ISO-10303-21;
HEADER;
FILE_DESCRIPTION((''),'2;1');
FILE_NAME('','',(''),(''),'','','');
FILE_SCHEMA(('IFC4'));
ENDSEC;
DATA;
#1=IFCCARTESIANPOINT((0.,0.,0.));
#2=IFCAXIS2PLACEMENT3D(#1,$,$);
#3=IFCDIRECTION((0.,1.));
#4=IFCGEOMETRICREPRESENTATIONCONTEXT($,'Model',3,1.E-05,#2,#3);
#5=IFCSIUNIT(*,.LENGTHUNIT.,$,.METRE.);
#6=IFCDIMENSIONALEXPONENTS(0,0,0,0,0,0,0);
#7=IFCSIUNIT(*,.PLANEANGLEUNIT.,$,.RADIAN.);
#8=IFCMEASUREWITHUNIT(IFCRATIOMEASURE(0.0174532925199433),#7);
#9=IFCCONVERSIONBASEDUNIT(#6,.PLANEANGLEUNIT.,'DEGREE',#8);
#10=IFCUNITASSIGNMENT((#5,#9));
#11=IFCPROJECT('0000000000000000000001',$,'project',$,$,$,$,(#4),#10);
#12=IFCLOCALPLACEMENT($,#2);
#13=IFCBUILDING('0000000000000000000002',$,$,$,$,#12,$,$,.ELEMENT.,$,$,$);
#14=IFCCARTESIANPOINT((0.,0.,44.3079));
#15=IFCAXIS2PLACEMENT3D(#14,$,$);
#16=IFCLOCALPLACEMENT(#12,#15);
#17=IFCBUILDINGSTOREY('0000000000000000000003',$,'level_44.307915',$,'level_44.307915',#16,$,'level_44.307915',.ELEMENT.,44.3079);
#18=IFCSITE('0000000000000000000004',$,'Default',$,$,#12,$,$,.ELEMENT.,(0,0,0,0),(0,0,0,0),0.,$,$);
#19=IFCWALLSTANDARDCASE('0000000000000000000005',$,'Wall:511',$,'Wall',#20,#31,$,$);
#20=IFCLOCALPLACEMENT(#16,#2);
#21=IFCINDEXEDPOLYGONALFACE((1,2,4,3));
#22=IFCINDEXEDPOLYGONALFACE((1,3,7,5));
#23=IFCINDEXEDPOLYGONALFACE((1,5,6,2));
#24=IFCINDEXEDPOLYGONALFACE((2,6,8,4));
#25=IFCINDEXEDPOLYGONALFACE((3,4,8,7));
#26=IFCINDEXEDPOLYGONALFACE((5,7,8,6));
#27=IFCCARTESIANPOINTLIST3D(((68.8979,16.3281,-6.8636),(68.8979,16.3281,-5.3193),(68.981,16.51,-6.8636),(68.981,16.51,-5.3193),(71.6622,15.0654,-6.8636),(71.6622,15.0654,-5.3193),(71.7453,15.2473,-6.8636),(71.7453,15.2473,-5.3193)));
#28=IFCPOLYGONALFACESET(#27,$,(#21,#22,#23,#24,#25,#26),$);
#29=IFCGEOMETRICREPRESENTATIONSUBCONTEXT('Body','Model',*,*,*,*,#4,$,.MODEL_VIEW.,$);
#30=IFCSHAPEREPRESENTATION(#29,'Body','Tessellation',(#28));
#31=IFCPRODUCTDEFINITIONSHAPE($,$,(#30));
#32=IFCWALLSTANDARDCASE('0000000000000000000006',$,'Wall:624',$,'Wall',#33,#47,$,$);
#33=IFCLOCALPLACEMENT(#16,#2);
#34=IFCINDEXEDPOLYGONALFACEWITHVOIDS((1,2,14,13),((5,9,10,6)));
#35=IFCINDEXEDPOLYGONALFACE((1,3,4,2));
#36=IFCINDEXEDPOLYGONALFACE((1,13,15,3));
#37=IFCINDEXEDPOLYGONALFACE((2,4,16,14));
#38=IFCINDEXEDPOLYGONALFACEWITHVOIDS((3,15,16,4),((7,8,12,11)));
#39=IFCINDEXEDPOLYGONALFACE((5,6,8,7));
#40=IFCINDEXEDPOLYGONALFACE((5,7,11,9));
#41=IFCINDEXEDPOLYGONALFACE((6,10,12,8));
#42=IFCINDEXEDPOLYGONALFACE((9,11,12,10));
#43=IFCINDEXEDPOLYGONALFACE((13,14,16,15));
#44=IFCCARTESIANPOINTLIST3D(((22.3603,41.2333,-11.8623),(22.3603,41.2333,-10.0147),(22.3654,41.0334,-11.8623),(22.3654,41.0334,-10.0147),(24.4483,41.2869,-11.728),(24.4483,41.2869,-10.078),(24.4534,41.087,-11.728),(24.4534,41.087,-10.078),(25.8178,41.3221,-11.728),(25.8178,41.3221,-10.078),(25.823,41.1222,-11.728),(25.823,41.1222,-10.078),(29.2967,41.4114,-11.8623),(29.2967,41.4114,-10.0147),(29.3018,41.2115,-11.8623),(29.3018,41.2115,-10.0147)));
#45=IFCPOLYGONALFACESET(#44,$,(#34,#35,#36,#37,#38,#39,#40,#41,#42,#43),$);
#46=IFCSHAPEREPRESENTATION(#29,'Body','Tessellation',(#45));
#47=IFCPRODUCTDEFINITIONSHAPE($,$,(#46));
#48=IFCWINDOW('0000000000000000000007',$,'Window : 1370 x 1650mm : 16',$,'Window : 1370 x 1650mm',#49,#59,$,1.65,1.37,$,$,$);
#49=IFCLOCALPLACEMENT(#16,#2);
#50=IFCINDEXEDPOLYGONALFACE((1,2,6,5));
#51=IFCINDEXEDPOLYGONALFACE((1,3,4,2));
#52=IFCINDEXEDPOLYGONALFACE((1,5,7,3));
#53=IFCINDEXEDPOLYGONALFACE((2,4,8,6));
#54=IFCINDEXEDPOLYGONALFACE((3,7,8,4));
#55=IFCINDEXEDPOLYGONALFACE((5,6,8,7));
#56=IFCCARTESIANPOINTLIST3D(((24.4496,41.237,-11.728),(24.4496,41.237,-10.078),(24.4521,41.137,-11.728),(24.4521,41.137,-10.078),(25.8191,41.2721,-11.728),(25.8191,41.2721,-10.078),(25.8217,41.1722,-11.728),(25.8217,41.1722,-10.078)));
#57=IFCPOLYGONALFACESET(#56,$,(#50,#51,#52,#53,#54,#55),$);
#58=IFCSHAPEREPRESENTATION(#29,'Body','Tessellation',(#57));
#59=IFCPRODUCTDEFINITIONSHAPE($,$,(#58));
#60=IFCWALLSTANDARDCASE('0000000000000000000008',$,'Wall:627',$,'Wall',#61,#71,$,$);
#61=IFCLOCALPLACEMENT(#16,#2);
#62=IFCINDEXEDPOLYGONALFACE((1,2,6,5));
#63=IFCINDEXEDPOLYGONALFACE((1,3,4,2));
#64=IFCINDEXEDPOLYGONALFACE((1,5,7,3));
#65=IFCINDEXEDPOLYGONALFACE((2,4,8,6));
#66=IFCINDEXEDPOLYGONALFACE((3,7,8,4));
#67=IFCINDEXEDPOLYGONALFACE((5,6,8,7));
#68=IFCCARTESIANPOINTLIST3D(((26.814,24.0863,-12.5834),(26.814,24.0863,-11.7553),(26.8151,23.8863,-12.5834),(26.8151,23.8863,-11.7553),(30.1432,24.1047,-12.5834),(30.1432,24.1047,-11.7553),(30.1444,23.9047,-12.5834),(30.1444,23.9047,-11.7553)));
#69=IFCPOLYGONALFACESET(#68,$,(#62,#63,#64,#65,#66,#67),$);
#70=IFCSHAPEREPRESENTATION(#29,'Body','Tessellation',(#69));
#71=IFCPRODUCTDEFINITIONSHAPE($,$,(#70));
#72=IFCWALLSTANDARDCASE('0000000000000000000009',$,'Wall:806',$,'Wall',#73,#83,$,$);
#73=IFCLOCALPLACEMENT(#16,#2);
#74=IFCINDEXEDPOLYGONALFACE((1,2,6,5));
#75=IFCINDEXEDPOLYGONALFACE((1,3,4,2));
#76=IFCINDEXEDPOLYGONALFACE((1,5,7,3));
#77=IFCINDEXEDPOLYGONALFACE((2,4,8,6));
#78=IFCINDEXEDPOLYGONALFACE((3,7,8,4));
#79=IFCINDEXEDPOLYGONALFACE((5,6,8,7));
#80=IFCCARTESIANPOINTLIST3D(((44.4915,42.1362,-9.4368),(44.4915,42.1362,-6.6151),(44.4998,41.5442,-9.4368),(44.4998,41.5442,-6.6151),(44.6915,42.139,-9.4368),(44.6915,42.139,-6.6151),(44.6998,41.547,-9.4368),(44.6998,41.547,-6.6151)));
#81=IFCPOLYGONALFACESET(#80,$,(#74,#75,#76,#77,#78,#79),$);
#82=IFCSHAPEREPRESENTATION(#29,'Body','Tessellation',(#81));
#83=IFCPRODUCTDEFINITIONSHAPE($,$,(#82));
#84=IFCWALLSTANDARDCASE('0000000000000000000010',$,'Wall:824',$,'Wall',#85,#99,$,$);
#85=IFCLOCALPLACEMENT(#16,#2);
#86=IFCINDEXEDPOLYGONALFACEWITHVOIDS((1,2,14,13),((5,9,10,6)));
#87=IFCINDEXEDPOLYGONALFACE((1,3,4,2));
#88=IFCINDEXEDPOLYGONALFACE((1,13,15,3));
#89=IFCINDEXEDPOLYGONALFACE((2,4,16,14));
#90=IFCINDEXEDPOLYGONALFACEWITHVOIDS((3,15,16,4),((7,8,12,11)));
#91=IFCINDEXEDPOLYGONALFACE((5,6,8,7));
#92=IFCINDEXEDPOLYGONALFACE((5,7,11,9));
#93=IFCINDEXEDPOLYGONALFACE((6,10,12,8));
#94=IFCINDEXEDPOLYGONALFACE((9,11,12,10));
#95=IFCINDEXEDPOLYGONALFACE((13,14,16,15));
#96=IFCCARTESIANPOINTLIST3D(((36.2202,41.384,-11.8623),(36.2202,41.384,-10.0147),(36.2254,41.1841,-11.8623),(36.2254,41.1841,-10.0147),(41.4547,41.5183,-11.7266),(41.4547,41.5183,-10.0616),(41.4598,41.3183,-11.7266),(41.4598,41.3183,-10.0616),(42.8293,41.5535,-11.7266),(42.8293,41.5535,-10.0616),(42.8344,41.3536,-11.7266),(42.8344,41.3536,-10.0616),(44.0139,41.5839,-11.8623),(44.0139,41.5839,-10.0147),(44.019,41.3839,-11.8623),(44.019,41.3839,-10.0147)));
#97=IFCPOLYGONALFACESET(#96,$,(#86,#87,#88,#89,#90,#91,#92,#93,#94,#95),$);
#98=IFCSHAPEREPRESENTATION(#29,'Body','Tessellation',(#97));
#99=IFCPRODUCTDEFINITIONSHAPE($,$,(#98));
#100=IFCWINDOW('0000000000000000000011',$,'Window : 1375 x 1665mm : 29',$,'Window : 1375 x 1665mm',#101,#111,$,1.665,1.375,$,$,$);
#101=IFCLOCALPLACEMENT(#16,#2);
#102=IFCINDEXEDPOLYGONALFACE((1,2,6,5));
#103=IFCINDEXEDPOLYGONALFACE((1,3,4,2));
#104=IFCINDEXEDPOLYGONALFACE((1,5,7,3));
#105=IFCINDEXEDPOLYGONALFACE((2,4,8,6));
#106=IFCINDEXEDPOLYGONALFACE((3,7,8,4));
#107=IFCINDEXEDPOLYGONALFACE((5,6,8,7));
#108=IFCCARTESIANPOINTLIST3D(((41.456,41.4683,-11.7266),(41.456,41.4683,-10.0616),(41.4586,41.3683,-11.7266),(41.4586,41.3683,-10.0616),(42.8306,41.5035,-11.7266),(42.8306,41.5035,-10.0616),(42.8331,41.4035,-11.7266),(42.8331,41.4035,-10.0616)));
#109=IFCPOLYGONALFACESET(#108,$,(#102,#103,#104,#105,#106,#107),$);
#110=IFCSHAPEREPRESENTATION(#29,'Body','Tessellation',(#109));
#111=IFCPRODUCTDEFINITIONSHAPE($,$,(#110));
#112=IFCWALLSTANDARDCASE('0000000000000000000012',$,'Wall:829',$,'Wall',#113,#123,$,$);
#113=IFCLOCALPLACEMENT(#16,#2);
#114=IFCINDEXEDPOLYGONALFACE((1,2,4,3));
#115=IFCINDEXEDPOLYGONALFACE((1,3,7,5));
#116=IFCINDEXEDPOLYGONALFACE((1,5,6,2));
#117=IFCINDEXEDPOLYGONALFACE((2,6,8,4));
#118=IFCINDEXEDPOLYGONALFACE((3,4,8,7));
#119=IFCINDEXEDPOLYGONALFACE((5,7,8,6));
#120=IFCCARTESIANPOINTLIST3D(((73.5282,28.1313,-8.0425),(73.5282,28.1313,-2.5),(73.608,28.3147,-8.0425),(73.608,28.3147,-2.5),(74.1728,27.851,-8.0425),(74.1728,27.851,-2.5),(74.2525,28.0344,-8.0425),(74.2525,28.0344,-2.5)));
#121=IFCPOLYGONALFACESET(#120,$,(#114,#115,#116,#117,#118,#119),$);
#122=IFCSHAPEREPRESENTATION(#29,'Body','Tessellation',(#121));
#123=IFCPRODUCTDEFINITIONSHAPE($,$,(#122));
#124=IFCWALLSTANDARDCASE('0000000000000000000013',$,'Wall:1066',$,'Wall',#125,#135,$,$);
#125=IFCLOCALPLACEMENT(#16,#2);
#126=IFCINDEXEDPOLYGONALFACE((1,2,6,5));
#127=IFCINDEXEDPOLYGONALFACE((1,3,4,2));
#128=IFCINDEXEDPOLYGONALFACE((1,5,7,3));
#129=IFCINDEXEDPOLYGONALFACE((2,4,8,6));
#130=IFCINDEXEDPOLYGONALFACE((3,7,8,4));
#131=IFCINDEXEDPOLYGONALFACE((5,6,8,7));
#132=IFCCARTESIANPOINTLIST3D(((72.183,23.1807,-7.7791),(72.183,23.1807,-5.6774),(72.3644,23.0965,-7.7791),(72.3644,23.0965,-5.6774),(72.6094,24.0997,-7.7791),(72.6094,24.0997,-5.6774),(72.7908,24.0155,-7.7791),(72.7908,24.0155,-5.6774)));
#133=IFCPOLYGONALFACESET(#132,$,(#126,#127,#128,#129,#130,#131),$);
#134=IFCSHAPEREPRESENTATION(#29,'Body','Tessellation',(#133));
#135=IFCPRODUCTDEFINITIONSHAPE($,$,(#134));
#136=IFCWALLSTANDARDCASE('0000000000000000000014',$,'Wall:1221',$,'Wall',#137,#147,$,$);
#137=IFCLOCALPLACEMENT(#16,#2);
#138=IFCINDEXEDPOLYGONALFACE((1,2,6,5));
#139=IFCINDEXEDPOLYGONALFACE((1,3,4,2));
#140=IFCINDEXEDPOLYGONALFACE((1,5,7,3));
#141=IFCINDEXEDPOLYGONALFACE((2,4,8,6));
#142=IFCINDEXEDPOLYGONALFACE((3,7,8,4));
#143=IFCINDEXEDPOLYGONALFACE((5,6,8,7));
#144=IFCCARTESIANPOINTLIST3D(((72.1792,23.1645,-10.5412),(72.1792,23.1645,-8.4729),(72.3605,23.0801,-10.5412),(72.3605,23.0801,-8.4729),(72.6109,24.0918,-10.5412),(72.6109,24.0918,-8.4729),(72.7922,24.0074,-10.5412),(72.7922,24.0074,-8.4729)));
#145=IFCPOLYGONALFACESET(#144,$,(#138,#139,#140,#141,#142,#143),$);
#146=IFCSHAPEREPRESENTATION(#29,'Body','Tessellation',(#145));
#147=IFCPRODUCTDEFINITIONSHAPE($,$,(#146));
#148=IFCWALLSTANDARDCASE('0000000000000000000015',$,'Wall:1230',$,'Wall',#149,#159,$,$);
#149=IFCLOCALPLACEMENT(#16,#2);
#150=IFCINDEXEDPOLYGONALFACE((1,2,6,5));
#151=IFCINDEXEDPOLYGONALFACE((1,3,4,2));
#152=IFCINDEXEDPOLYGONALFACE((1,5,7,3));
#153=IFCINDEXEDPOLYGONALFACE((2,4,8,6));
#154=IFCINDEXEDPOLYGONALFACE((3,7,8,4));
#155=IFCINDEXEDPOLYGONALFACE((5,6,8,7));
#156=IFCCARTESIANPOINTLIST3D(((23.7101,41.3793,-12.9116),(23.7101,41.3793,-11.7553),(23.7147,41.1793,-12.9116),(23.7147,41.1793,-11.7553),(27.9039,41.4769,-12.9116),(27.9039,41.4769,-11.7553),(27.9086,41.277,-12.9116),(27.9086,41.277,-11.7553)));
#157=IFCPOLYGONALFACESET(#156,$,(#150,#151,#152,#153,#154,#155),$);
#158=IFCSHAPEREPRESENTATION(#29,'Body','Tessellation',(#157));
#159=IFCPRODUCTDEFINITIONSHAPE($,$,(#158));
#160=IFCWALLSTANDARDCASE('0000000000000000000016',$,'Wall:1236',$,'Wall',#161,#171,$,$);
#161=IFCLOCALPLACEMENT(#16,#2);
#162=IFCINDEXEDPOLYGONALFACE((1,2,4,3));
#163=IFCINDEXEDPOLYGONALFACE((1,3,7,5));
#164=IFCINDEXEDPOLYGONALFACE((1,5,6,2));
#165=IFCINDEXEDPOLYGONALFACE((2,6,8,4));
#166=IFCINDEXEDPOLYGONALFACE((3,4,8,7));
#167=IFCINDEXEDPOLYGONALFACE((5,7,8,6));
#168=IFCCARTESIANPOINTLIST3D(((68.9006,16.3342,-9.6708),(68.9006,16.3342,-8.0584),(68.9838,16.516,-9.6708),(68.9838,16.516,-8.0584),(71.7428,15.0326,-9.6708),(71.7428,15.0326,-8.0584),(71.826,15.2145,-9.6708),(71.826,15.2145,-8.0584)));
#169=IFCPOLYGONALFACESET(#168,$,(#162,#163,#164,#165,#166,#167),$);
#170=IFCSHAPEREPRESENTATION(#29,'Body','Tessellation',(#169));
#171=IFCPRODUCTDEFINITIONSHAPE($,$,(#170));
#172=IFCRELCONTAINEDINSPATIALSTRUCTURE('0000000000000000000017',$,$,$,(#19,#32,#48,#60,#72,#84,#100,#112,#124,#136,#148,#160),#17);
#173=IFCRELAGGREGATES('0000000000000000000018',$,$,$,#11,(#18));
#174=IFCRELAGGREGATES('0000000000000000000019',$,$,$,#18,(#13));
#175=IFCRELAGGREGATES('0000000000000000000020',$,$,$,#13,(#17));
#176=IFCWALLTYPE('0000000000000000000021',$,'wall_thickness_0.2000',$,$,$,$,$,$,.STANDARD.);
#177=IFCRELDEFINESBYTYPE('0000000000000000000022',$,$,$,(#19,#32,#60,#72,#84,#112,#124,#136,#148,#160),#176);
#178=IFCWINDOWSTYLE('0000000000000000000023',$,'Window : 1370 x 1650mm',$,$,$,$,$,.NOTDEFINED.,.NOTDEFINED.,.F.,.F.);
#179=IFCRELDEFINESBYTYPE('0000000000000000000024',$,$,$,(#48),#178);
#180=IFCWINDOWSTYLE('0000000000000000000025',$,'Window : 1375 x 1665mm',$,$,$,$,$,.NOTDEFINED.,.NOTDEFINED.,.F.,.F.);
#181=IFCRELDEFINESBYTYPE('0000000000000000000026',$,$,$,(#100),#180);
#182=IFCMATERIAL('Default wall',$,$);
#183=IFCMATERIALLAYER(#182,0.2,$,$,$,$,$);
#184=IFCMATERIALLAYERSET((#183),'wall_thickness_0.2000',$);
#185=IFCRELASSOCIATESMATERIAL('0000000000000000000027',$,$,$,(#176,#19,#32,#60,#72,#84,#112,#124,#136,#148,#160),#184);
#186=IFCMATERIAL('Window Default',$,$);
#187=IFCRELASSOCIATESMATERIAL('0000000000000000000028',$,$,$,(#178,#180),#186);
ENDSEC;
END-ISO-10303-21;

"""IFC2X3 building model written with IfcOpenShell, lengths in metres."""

from ifc_helpers import new_model, entity, si_unit, converted_unit, direction, frame, frame_2d, origin, origin_2d_with_axis, place, context, subcontext, project, spatial, polyline, rectangle, outline, extrude, source, transform, mapped, material, layer, layer_set, layer_usage, type_object, type_shapes, element, fill, save


model = new_model("IFC2X3")

# Units and contexts
model_context = context("Model", 3, precision=1e-05, world=origin(), true_north=direction((0.0, 1.0)))
body_context = subcontext(model_context, "Body", "Model", "MODEL_VIEW")
ifc_project = project(units=[si_unit("LENGTHUNIT", "METRE"), converted_unit("PLANEANGLEUNIT", "DEGREE", entity("IfcRatioMeasure", 0.0174532925199433), si_unit("PLANEANGLEUNIT", "RADIAN"), dimensions=[0, 0, 0, 0, 0, 0, 0])], contexts=[model_context])

# Site, building, storey
placement_1 = place(None, origin())
site = spatial("IfcSite", under=ifc_project, at=placement_1, Name="Default", CompositionType="ELEMENT", RefLatitude=(0, 0, 0, 0), RefLongitude=(0, 0, 0, 0), RefElevation=0.0)
building = spatial("IfcBuilding", under=site, at=placement_1, CompositionType="ELEMENT")
storey_placement = place(placement_1, frame((0.0, 0.0, 44.3079)))
storey = spatial("IfcBuildingStorey", under=building, at=storey_placement, Name="level_44.307915", ObjectType="level_44.307915", LongName="level_44.307915", CompositionType="ELEMENT", Elevation=44.3079)

# Shared definitions
ifc_material_1 = material(Name="Default wall")
ifc_layer = layer(ifc_material_1, 0.2)
ifc_layer_set = layer_set([ifc_layer], Name="wall_thickness_0.2000")
ifc_layer_usage = layer_usage(ifc_layer_set, "AXIS2", "POSITIVE", -0.1)
wall_type = type_object("IfcWallType", Name="wall_thickness_0.2000", PredefinedType="STANDARD", material=ifc_layer_set)

# Shared definitions
ifc_material_2 = material(Name="Window Default")

# Wall
placement_2 = place(placement_1, frame((0.0, 0.0, 37.4443)))
wall_1_placement = place(placement_2, frame((68.9394, 16.4191, 0.0), z_axis=(0.0, 0.0, 1.0), x_axis=(0.909599, -0.415487, 0.0)))
element("IfcWallStandardCase", 1, at=wall_1_placement, inside=storey, type_object=wall_type, material=ifc_layer_usage, Name="Wall:511", ObjectType="Wall", context=body_context, shape_type="SweptSolid", body=[
    extrude(outline(polyline([(3.039, -0.1), (3.039, 0.1), (0.0, 0.1), (0.0, -0.1), (3.039, -0.1)])), origin(), (0.0, 0.0, 1.0), 1.5443),
])

# Wall, opening, window
placement_3 = place(placement_1, frame((0.0, 0.0, 32.4456)))
wall_2_placement = place(placement_3, frame((22.3628, 41.1334, 0.0), z_axis=(0.0, 0.0, 1.0), x_axis=(0.999671, 0.025669, 0.0)))
wall_2 = element("IfcWallStandardCase", 2, at=wall_2_placement, inside=storey, type_object=wall_type, material=ifc_layer_usage, Name="Wall:624", ObjectType="Wall", context=body_context, shape_type="SweptSolid", body=[
    extrude(outline(polyline([(6.9387, -0.1), (6.9387, 0.1), (0.0, 0.1), (0.0, -0.1), (6.9387, -0.1)])), origin(), (0.0, 0.0, 1.0), 1.8476),
])
opening_1_placement = place(wall_2_placement, frame((2.0887, -0.1, 0.1344)))
opening_1 = element("IfcOpeningElement", 3, at=opening_1_placement, cuts=wall_2, ObjectType="Opening", context=body_context, shape_type="SweptSolid", body=[
    extrude(rectangle(XDim=1.37, YDim=1.65, at=frame_2d((0.825, 0.685), x_axis=(0.0, 1.0))), frame((0.0, 0.0, 0.0), z_axis=(0.0, 1.0, 0.0), x_axis=(0.0, 0.0, 1.0)), (0.0, 0.0, 1.0), 0.2),
])
window_style_1 = type_object("IfcWindowStyle", Name="Window : 1370 x 1650mm", ConstructionType="NOTDEFINED", OperationType="NOTDEFINED", ParameterTakesPrecedence=False, Sizeable=False, material=ifc_material_2)
shared_shape_1 = source(origin(), body_context, "Body", "SweptSolid", [
    extrude(rectangle(XDim=0.1, YDim=1.37, at=origin_2d_with_axis()), frame((0.685, 0.1, 0.0), z_axis=(0.0, 0.0, 1.0), x_axis=(0.0, 1.0, 0.0)), (0.0, 0.0, 1.0), 1.65),
])
type_shapes(window_style_1, [shared_shape_1])
window_1_placement = place(opening_1_placement, origin())
window_1 = element("IfcWindow", 4, at=window_1_placement, inside=storey, type_object=window_style_1, Name="Window : 1370 x 1650mm : 16", ObjectType="Window : 1370 x 1650mm", OverallHeight=1.65, OverallWidth=1.37, context=body_context, shape_type="MappedRepresentation", body=[
    mapped(shared_shape_1, transform((0.0, 0.0, 0.0), scale=1.0)),
])
fill(opening_1, window_1)

# Walls
placement_4 = place(placement_1, frame((0.0, 0.0, 31.7245)))
wall_3_placement = place(placement_4, frame((26.8146, 23.9863, 0.0), z_axis=(0.0, 0.0, 1.0), x_axis=(0.999985, 0.005525, 0.0)))
element("IfcWallStandardCase", 5, at=wall_3_placement, inside=storey, type_object=wall_type, material=ifc_layer_usage, Name="Wall:627", ObjectType="Wall", context=body_context, shape_type="SweptSolid", body=[
    extrude(outline(polyline([(3.3293, -0.1), (3.3293, 0.1), (0.0, 0.1), (0.0, -0.1), (3.3293, -0.1)])), origin(), (0.0, 0.0, 1.0), 0.8281),
])
placement_5 = place(placement_1, frame((0.0, 0.0, 34.8711)))
wall_4_placement = place(placement_5, frame((44.5998, 41.5456, 0.0), z_axis=(0.0, 0.0, 1.0), x_axis=(-0.014001, 0.999902, 0.0)))
element("IfcWallStandardCase", 6, at=wall_4_placement, inside=storey, type_object=wall_type, material=ifc_layer_usage, Name="Wall:806", ObjectType="Wall", context=body_context, shape_type="SweptSolid", body=[
    extrude(outline(polyline([(0.5921, -0.1), (0.5921, 0.1), (0.0, 0.1), (0.0, -0.1), (0.5921, -0.1)])), origin(), (0.0, 0.0, 1.0), 2.8217),
])

# Wall, opening, window
placement_6 = place(placement_1, frame((0.0, 0.0, 32.4456)))
wall_5_placement = place(placement_6, frame((36.2228, 41.2841, 0.0), z_axis=(0.0, 0.0, 1.0), x_axis=(0.999671, 0.025631, 0.0)))
wall_5 = element("IfcWallStandardCase", 7, at=wall_5_placement, inside=storey, type_object=wall_type, material=ifc_layer_usage, Name="Wall:824", ObjectType="Wall", context=body_context, shape_type="SweptSolid", body=[
    extrude(outline(polyline([(7.7962, -0.1), (7.7962, 0.1), (0.0, 0.1), (0.0, -0.1), (7.7962, -0.1)])), origin(), (0.0, 0.0, 1.0), 1.8476),
])
opening_2_placement = place(wall_5_placement, frame((5.2362, -0.1, 0.1357)))
opening_2 = element("IfcOpeningElement", 8, at=opening_2_placement, cuts=wall_5, ObjectType="Opening", context=body_context, shape_type="SweptSolid", body=[
    extrude(rectangle(XDim=1.375, YDim=1.665, at=frame_2d((0.8325, 0.6875), x_axis=(0.0, 1.0))), frame((0.0, 0.0, 0.0), z_axis=(0.0, 1.0, 0.0), x_axis=(0.0, 0.0, 1.0)), (0.0, 0.0, 1.0), 0.2),
])
window_style_2 = type_object("IfcWindowStyle", Name="Window : 1375 x 1665mm", ConstructionType="NOTDEFINED", OperationType="NOTDEFINED", ParameterTakesPrecedence=False, Sizeable=False, material=ifc_material_2)
shared_shape_2 = source(origin(), body_context, "Body", "SweptSolid", [
    extrude(rectangle(XDim=0.1, YDim=1.375, at=origin_2d_with_axis()), frame((0.6875, 0.1, 0.0), z_axis=(0.0, 0.0, 1.0), x_axis=(0.0, 1.0, 0.0)), (0.0, 0.0, 1.0), 1.665),
])
type_shapes(window_style_2, [shared_shape_2])
window_2_placement = place(opening_2_placement, origin())
window_2 = element("IfcWindow", 9, at=window_2_placement, inside=storey, type_object=window_style_2, Name="Window : 1375 x 1665mm : 29", ObjectType="Window : 1375 x 1665mm", OverallHeight=1.665, OverallWidth=1.375, context=body_context, shape_type="MappedRepresentation", body=[
    mapped(shared_shape_2, transform((0.0, 0.0, 0.0), scale=1.0)),
])
fill(opening_2, window_2)

# Walls
placement_7 = place(placement_1, frame((0.0, 0.0, 36.2654)))
wall_6_placement = place(placement_7, frame((74.2127, 27.9427, 0.0), z_axis=(0.0, 0.0, 1.0), x_axis=(-0.917025, 0.398831, 0.0)))
element("IfcWallStandardCase", 10, at=wall_6_placement, inside=storey, type_object=wall_type, material=ifc_layer_usage, Name="Wall:829", ObjectType="Wall", context=body_context, shape_type="SweptSolid", body=[
    extrude(outline(polyline([(0.7029, -0.1), (0.7029, 0.1), (0.0, 0.1), (0.0, -0.1), (0.7029, -0.1)])), origin(), (0.0, 0.0, 1.0), 5.5425),
])
placement_8 = place(placement_1, frame((0.0, 0.0, 36.5288)))
wall_7_placement = place(placement_8, frame((72.2737, 23.1386, 0.0), z_axis=(0.0, 0.0, 1.0), x_axis=(0.420886, 0.907114, 0.0)))
element("IfcWallStandardCase", 11, at=wall_7_placement, inside=storey, type_object=wall_type, material=ifc_layer_usage, Name="Wall:1066", ObjectType="Wall", context=body_context, shape_type="SweptSolid", body=[
    extrude(outline(polyline([(1.0131, -0.1), (1.0131, 0.1), (0.0, 0.1), (0.0, -0.1), (1.0131, -0.1)])), origin(), (0.0, 0.0, 1.0), 2.1017),
])
placement_9 = place(placement_1, frame((0.0, 0.0, 33.7667)))
wall_8_placement = place(placement_9, frame((72.2698, 23.1223, 0.0), z_axis=(0.0, 0.0, 1.0), x_axis=(0.422088, 0.906555, 0.0)))
element("IfcWallStandardCase", 12, at=wall_8_placement, inside=storey, type_object=wall_type, material=ifc_layer_usage, Name="Wall:1221", ObjectType="Wall", context=body_context, shape_type="SweptSolid", body=[
    extrude(outline(polyline([(1.0228, -0.1), (1.0228, 0.1), (0.0, 0.1), (0.0, -0.1), (1.0228, -0.1)])), origin(), (0.0, 0.0, 1.0), 2.0683),
])
placement_10 = place(placement_1, frame((0.0, 0.0, 31.3963)))
wall_9_placement = place(placement_10, frame((23.7124, 41.2793, 0.0), z_axis=(0.0, 0.0, 1.0), x_axis=(0.999729, 0.023282, 0.0)))
element("IfcWallStandardCase", 13, at=wall_9_placement, inside=storey, type_object=wall_type, material=ifc_layer_usage, Name="Wall:1230", ObjectType="Wall", context=body_context, shape_type="SweptSolid", body=[
    extrude(outline(polyline([(4.195, -0.1), (4.195, 0.1), (0.0, 0.1), (0.0, -0.1), (4.195, -0.1)])), origin(), (0.0, 0.0, 1.0), 1.1563),
])
placement_11 = place(placement_1, frame((0.0, 0.0, 34.6371)))
wall_10_placement = place(placement_11, frame((68.9422, 16.4251, 0.0), z_axis=(0.0, 0.0, 1.0), x_axis=(0.909201, -0.416357, 0.0)))
element("IfcWallStandardCase", 14, at=wall_10_placement, inside=storey, type_object=wall_type, material=ifc_layer_usage, Name="Wall:1236", ObjectType="Wall", context=body_context, shape_type="SweptSolid", body=[
    extrude(outline(polyline([(3.126, -0.1), (3.126, 0.1), (0.0, 0.1), (0.0, -0.1), (3.126, -0.1)])), origin(), (0.0, 0.0, 1.0), 1.6124),
])

save(model, "model.ifc")
